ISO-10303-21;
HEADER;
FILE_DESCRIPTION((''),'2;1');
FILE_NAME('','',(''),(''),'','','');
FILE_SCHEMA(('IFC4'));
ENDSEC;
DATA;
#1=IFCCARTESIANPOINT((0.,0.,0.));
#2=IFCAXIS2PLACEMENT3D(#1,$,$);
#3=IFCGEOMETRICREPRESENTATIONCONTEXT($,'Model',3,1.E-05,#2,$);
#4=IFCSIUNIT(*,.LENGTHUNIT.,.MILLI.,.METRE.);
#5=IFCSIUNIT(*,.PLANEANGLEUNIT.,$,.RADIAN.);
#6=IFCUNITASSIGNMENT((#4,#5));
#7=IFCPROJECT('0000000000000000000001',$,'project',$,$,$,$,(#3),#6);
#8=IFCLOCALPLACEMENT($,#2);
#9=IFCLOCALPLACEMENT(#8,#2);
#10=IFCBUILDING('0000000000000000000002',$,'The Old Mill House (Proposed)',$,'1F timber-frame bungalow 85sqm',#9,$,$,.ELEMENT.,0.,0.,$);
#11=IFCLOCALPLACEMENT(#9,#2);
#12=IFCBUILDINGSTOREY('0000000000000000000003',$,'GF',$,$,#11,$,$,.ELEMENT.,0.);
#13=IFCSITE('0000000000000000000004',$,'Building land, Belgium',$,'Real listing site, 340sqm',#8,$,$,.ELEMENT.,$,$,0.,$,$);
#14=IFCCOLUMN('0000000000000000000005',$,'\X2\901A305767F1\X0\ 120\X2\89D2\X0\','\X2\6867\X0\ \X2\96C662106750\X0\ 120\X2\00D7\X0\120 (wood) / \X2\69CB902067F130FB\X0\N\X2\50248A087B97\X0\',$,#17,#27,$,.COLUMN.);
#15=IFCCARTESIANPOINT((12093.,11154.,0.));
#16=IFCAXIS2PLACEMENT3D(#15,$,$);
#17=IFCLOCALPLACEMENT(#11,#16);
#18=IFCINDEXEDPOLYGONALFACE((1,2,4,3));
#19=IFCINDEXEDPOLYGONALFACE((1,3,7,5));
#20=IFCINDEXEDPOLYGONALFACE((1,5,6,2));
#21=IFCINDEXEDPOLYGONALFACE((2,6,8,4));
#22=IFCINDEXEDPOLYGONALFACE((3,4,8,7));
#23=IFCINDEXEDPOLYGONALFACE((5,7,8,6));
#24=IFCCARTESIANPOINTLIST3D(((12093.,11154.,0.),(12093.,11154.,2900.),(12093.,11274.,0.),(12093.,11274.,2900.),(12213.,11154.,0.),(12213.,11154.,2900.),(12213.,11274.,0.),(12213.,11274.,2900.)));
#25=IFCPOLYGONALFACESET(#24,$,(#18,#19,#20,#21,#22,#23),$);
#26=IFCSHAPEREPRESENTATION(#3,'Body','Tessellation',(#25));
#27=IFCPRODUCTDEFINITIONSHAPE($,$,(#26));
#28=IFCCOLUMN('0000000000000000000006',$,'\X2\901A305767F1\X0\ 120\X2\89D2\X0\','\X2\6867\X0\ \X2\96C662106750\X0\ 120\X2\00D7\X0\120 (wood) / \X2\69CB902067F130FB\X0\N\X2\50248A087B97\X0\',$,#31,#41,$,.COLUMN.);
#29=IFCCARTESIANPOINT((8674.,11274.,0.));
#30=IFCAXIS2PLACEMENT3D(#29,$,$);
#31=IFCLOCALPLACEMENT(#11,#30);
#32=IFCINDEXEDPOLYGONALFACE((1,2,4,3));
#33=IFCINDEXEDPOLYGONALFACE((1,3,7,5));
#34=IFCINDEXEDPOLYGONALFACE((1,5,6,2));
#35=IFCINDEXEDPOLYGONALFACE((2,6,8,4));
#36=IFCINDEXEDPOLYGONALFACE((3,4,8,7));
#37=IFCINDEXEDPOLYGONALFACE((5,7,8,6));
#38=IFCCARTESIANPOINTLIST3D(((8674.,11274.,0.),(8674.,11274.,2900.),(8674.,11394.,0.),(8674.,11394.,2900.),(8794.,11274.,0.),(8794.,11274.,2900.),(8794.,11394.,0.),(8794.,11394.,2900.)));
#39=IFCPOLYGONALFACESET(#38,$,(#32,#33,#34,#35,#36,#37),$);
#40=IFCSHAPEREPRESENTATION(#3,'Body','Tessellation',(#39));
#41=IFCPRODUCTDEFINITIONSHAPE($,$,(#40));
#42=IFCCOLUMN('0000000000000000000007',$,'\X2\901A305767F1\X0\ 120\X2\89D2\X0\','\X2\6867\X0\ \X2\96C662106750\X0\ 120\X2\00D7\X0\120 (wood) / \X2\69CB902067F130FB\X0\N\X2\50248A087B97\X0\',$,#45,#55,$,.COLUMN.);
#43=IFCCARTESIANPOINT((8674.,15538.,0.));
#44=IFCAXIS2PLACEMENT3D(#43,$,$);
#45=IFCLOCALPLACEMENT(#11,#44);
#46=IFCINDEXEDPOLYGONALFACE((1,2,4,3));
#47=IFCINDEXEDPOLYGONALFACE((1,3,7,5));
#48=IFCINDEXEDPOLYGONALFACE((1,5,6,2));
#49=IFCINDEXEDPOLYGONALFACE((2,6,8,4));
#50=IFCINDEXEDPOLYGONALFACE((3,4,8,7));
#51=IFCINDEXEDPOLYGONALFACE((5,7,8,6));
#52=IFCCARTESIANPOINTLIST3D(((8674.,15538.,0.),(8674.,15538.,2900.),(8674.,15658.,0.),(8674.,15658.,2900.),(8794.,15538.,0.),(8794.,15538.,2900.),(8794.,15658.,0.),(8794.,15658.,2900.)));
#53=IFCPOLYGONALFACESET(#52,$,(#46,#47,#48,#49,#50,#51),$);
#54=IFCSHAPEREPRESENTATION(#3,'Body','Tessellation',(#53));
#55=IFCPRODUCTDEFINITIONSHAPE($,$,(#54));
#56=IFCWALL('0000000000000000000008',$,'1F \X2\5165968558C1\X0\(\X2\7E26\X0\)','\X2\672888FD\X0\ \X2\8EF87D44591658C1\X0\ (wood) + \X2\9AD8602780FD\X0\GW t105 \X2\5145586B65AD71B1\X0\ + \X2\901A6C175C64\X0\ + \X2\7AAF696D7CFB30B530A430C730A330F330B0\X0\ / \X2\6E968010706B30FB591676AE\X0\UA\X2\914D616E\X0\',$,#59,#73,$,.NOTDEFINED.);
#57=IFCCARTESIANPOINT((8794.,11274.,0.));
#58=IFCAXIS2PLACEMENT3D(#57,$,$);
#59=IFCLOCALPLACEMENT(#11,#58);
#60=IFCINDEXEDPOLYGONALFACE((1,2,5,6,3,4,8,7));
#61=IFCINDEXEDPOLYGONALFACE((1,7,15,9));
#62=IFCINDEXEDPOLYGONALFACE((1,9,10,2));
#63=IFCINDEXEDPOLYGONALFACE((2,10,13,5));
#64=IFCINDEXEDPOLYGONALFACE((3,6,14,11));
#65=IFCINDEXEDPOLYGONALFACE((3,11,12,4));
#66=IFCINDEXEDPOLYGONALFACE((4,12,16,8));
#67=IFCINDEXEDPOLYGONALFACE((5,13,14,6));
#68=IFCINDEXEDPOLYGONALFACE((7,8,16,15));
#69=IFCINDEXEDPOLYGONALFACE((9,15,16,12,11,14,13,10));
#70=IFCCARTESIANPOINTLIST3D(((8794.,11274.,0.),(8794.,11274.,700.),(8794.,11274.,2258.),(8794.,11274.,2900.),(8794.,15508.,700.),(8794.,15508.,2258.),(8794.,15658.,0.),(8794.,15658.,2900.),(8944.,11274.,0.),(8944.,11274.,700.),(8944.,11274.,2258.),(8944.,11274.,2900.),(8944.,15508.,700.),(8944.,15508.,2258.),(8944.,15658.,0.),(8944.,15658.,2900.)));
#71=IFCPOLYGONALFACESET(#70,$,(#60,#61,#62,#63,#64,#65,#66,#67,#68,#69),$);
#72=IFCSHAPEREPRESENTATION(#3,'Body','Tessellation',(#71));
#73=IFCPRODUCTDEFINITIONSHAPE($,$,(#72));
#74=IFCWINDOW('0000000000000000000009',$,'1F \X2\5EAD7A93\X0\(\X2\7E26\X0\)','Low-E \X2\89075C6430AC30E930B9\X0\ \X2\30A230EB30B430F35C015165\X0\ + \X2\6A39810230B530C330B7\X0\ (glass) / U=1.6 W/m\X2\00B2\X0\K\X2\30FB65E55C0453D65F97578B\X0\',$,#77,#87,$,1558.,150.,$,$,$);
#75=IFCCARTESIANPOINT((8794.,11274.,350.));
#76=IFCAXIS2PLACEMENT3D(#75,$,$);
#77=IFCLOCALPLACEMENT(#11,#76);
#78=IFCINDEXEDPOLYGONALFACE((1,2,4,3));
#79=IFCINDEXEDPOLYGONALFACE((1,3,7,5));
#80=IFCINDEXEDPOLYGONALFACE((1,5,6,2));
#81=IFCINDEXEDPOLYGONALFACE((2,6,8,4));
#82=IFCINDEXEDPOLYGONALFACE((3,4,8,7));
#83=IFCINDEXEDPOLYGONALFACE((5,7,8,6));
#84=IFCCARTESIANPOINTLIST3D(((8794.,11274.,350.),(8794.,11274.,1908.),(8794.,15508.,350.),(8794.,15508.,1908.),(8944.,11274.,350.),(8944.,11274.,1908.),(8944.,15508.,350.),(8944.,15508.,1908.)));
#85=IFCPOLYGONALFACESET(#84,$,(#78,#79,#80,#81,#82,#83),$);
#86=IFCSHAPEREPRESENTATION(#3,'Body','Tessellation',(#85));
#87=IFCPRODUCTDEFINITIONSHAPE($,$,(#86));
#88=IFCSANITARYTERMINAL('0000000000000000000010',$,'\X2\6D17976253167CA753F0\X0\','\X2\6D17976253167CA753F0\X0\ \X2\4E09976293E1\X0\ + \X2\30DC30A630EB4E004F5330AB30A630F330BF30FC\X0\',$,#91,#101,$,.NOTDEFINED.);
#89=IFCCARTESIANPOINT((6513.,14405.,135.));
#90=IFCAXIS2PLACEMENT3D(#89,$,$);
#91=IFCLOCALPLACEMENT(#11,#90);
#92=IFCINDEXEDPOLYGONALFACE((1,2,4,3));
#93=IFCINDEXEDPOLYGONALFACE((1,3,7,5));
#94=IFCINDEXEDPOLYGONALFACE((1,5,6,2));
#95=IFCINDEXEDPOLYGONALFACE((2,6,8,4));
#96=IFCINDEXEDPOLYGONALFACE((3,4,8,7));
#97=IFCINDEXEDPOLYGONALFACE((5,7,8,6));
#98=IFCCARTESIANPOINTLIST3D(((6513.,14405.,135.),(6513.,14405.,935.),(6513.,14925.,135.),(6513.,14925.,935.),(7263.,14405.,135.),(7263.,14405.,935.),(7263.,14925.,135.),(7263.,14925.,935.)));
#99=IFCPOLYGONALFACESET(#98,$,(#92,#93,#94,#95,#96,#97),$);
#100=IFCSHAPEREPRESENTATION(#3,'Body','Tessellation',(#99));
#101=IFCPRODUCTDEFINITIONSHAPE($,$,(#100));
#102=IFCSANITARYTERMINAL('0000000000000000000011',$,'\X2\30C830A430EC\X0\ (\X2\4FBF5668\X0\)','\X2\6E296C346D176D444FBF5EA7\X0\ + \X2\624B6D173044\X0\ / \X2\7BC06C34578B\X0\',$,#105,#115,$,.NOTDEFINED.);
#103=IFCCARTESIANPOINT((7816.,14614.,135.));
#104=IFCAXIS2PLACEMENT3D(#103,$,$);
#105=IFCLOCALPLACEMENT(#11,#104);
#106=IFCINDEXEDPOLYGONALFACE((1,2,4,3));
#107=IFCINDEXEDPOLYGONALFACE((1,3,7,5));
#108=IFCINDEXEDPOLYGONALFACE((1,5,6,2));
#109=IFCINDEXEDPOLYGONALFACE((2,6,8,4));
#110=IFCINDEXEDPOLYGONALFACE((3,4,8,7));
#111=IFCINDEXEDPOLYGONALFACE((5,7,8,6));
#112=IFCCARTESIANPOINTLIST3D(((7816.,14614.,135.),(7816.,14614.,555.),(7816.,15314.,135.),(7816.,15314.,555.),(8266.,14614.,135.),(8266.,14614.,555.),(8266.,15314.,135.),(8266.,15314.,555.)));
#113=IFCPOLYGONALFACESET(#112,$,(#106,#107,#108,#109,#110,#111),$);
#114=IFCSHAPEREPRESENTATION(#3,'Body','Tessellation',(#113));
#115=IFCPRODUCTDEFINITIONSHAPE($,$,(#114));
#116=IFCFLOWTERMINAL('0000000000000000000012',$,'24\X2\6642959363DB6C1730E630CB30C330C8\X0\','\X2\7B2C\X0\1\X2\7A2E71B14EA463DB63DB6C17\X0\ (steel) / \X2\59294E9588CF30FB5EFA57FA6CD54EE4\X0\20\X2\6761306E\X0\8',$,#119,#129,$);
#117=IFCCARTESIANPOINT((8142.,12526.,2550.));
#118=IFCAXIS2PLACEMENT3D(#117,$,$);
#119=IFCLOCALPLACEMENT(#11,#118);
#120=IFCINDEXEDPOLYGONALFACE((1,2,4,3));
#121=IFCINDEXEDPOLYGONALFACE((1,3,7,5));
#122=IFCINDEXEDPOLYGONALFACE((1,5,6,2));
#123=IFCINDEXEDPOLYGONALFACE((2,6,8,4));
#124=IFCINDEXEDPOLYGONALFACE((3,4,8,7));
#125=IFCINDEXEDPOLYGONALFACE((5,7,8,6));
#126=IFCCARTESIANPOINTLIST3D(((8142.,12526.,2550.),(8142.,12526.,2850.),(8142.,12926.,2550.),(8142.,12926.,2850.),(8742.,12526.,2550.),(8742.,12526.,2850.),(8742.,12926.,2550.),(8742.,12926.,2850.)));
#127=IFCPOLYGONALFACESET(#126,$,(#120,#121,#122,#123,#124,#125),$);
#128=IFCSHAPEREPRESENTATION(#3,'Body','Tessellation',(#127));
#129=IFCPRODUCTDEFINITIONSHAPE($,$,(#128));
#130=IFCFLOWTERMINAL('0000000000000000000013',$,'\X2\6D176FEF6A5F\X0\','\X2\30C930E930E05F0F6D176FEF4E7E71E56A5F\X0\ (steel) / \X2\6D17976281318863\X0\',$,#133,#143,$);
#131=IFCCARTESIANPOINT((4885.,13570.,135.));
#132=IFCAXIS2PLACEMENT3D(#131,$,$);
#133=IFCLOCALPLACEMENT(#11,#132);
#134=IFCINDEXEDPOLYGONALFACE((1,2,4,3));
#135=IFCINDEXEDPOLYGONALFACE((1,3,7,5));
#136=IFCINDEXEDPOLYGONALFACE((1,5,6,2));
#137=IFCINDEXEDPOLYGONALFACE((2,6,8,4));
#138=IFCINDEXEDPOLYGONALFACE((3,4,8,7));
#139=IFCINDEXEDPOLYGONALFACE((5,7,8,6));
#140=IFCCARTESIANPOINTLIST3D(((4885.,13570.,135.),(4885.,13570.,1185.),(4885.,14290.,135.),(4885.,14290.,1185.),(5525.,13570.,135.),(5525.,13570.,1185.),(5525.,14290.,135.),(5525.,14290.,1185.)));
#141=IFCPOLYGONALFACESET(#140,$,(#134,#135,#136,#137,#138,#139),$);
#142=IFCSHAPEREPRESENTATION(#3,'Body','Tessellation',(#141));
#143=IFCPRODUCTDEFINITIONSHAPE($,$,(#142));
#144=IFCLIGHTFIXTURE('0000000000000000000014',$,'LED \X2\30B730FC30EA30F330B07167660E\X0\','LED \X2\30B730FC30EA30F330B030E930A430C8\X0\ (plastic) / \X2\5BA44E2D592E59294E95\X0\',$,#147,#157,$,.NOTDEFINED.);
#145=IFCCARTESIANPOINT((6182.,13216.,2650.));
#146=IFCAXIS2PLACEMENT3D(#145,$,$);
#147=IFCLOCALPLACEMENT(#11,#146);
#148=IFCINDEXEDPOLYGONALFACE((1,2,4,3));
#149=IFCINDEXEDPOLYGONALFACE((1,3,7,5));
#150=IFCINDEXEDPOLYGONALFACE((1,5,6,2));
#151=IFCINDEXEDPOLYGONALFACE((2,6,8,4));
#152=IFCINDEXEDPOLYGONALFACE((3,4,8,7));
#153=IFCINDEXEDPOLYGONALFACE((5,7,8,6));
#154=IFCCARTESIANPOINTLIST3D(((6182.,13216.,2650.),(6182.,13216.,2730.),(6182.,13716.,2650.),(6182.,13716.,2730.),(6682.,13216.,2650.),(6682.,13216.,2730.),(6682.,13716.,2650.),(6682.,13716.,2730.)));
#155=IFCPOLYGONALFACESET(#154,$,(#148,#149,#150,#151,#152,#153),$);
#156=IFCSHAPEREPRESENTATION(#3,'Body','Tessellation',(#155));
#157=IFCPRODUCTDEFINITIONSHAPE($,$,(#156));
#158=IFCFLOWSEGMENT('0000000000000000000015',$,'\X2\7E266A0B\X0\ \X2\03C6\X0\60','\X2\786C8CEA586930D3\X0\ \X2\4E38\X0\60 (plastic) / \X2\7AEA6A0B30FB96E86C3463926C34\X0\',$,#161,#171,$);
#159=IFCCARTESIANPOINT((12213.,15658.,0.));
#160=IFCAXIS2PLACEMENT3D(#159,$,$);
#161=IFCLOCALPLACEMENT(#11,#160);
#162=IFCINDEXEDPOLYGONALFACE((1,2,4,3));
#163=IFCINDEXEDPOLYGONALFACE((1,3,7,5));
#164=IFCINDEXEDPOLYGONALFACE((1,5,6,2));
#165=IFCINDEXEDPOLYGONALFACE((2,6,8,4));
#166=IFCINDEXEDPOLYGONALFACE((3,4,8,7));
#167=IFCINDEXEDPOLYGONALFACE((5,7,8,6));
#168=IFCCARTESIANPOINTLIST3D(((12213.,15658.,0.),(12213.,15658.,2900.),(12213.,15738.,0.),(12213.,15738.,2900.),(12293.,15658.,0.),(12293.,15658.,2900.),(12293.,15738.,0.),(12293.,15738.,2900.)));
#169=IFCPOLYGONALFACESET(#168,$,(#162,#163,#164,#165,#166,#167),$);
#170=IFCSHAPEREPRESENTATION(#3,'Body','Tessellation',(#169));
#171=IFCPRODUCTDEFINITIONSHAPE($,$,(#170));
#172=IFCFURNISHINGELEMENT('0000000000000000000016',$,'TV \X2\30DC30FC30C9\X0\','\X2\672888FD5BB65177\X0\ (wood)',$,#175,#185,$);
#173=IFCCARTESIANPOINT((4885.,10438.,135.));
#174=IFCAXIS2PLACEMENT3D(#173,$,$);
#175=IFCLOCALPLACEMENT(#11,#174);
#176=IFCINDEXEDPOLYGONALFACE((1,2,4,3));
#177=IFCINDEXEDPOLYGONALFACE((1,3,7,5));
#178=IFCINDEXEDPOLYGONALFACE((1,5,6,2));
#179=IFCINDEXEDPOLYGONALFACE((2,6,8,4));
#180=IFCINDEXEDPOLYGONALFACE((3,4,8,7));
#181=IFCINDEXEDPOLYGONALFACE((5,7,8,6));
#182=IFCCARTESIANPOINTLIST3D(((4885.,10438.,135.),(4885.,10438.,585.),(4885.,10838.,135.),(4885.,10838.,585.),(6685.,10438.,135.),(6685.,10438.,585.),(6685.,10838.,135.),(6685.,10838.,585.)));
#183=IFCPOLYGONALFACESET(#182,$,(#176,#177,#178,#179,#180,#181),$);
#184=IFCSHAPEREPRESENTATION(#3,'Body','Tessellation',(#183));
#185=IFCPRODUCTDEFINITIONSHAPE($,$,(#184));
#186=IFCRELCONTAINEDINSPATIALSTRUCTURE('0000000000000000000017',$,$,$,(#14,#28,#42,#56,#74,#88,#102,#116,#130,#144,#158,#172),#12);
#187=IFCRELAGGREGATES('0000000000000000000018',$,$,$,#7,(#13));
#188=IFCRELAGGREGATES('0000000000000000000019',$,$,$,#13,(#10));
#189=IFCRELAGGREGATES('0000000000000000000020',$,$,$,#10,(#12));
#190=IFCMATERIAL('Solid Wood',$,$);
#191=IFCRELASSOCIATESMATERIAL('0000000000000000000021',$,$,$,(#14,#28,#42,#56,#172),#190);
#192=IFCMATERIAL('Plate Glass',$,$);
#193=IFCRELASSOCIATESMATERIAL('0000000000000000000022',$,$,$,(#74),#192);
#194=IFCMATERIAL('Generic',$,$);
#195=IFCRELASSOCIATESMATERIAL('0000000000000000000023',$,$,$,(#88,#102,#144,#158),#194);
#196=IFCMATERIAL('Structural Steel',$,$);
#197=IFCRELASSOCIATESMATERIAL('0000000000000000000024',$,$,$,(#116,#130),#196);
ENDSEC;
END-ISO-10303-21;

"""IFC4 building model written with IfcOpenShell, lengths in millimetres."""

from ifc_helpers import new_model, si_unit, frame, frame_2d, origin, place, context, project, spatial, rectangle, extrude, material, element, fill, save


model = new_model("IFC4")

# Units and contexts
model_context = context("Model", 3, precision=1e-05, world=origin())
ifc_project = project(units=[si_unit("LENGTHUNIT", "METRE", prefix="MILLI"), si_unit("PLANEANGLEUNIT", "RADIAN")], contexts=[model_context])

# Site, building, storey
site_placement = place(None, origin())
site = spatial("IfcSite", under=ifc_project, at=site_placement, Name="Building land, Belgium", ObjectType="Real listing site, 340sqm", CompositionType="ELEMENT", RefElevation=0.0)
building_placement = place(site_placement, origin())
building = spatial("IfcBuilding", under=site, at=building_placement, Name="The Old Mill House (Proposed)", ObjectType="1F timber-frame bungalow 85sqm", CompositionType="ELEMENT", ElevationOfRefHeight=0.0, ElevationOfTerrain=0.0)
storey_placement = place(building_placement, origin())
storey = spatial("IfcBuildingStorey", under=building, at=storey_placement, Name="GF", CompositionType="ELEMENT", Elevation=0.0)

# Columns
ifc_material_1 = material(Name="Solid Wood")
column_1_placement = place(storey_placement, frame((12093.0, 11154.0, 0.0)))
element("IfcColumn", 1, at=column_1_placement, inside=storey, material=ifc_material_1, Name="通し柱 120角", Description="桧 集成材 120×120 (wood) / 構造柱・N値計算", PredefinedType="COLUMN", context=model_context, shape_type="SweptSolid", body=[
    extrude(rectangle(XDim=120.0, YDim=120.0, at=frame_2d((60.0, 60.0))), frame((12093.0, 11154.0, 0.0)), (0.0, 0.0, 1.0), 2900.0),
])
column_2_placement = place(storey_placement, frame((8674.0, 11274.0, 0.0)))
element("IfcColumn", 2, at=column_2_placement, inside=storey, material=ifc_material_1, Name="通し柱 120角", Description="桧 集成材 120×120 (wood) / 構造柱・N値計算", PredefinedType="COLUMN", context=model_context, shape_type="SweptSolid", body=[
    extrude(rectangle(XDim=120.0, YDim=120.0, at=frame_2d((60.0, 60.0))), frame((8674.0, 11274.0, 0.0)), (0.0, 0.0, 1.0), 2900.0),
])
column_3_placement = place(storey_placement, frame((8674.0, 15538.0, 0.0)))
element("IfcColumn", 3, at=column_3_placement, inside=storey, material=ifc_material_1, Name="通し柱 120角", Description="桧 集成材 120×120 (wood) / 構造柱・N値計算", PredefinedType="COLUMN", context=model_context, shape_type="SweptSolid", body=[
    extrude(rectangle(XDim=120.0, YDim=120.0, at=frame_2d((60.0, 60.0))), frame((8674.0, 15538.0, 0.0)), (0.0, 0.0, 1.0), 2900.0),
])

# Wall, opening, window
wall_1_placement = place(storey_placement, frame((8794.0, 11274.0, 0.0)))
wall_1 = element("IfcWall", 4, at=wall_1_placement, inside=storey, material=ifc_material_1, Name="1F 入隅壁(縦)", Description="木製 軸組外壁 (wood) + 高性能GW t105 充填断熱 + 通気層 + 窯業系サイディング / 準耐火・外皮UA配慮", PredefinedType="NOTDEFINED", context=model_context, shape_type="SweptSolid", body=[
    extrude(rectangle(XDim=150.0, YDim=4384.0, at=frame_2d((75.0, 2192.0))), frame((8794.0, 11274.0, 0.0)), (0.0, 0.0, 1.0), 2900.0),
])
opening_placement = place(storey_placement, frame((8794.0, 11274.0, 350.0)))
opening = element("IfcOpeningElement", 5, at=opening_placement, cuts=wall_1, PredefinedType="NOTDEFINED", context=model_context, shape_type="SweptSolid", body=[
    extrude(rectangle(XDim=150.0, YDim=4234.0, at=frame_2d((75.0, 2117.0))), frame((8794.0, 11274.0, 350.0)), (0.0, 0.0, 1.0), 1558.0),
])
ifc_material_2 = material(Name="Plate Glass")
window_placement = place(storey_placement, frame((8794.0, 11274.0, 350.0)))
window = element("IfcWindow", 6, at=window_placement, inside=storey, material=ifc_material_2, Name="1F 庭窓(縦)", Description="Low-E 複層ガラス アルゴン封入 + 樹脂サッシ (glass) / U=1.6 W/m²K・日射取得型", OverallHeight=1558.0, OverallWidth=150.0, context=model_context, shape_type="SweptSolid", body=[
    extrude(rectangle(XDim=150.0, YDim=4234.0, at=frame_2d((75.0, 2117.0))), frame((8794.0, 11274.0, 350.0)), (0.0, 0.0, 1.0), 1558.0),
])
fill(opening, window)

# Sanitary terminals
ifc_material_3 = material(Name="Generic")
sanitary_terminal_1_placement = place(storey_placement, frame((6513.0, 14405.0, 135.0)))
element("IfcSanitaryTerminal", 7, at=sanitary_terminal_1_placement, inside=storey, material=ifc_material_3, Name="洗面化粧台", Description="洗面化粧台 三面鏡 + ボウル一体カウンター", PredefinedType="NOTDEFINED", context=model_context, shape_type="SweptSolid", body=[
    extrude(rectangle(XDim=750.0, YDim=520.0, at=frame_2d((375.0, 260.0))), frame((6513.0, 14405.0, 135.0)), (0.0, 0.0, 1.0), 800.0),
])
sanitary_terminal_2_placement = place(storey_placement, frame((7816.0, 14614.0, 135.0)))
element("IfcSanitaryTerminal", 8, at=sanitary_terminal_2_placement, inside=storey, material=ifc_material_3, Name="トイレ (便器)", Description="温水洗浄便座 + 手洗い / 節水型", PredefinedType="NOTDEFINED", context=model_context, shape_type="SweptSolid", body=[
    extrude(rectangle(XDim=450.0, YDim=700.0, at=frame_2d((225.0, 350.0))), frame((7816.0, 14614.0, 135.0)), (0.0, 0.0, 1.0), 420.0),
])

# Flow terminals
ifc_material_4 = material(Name="Structural Steel")
flow_terminal_1_placement = place(storey_placement, frame((8142.0, 12526.0, 2550.0)))
element("IfcFlowTerminal", 9, at=flow_terminal_1_placement, inside=storey, material=ifc_material_4, Name="24時間換気ユニット", Description="第1種熱交換換気 (steel) / 天井裏・建基法令20条の8", context=model_context, shape_type="SweptSolid", body=[
    extrude(rectangle(XDim=600.0, YDim=400.0, at=frame_2d((300.0, 200.0))), frame((8142.0, 12526.0, 2550.0)), (0.0, 0.0, 1.0), 300.0),
])
flow_terminal_2_placement = place(storey_placement, frame((4885.0, 13570.0, 135.0)))
element("IfcFlowTerminal", 10, at=flow_terminal_2_placement, inside=storey, material=ifc_material_4, Name="洗濯機", Description="ドラム式洗濯乾燥機 (steel) / 洗面脱衣", context=model_context, shape_type="SweptSolid", body=[
    extrude(rectangle(XDim=640.0, YDim=720.0, at=frame_2d((320.0, 360.0))), frame((4885.0, 13570.0, 135.0)), (0.0, 0.0, 1.0), 1050.0),
])

# Light fixture
light_fixture_placement = place(storey_placement, frame((6182.0, 13216.0, 2650.0)))
element("IfcLightFixture", 11, at=light_fixture_placement, inside=storey, material=ifc_material_3, Name="LED シーリング照明", Description="LED シーリングライト (plastic) / 室中央天井", PredefinedType="NOTDEFINED", context=model_context, shape_type="SweptSolid", body=[
    extrude(rectangle(XDim=500.0, YDim=500.0, at=frame_2d((250.0, 250.0))), frame((6182.0, 13216.0, 2650.0)), (0.0, 0.0, 1.0), 80.0),
])

# Flow segment
flow_segment_placement = place(storey_placement, frame((12213.0, 15658.0, 0.0)))
element("IfcFlowSegment", 12, at=flow_segment_placement, inside=storey, material=ifc_material_3, Name="縦樋 φ60", Description="硬質塩ビ 丸60 (plastic) / 竪樋・雨水排水", context=model_context, shape_type="SweptSolid", body=[
    extrude(rectangle(XDim=80.0, YDim=80.0, at=frame_2d((40.0, 40.0))), frame((12213.0, 15658.0, 0.0)), (0.0, 0.0, 1.0), 2900.0),
])

# Furnishing element
furnishing_placement = place(storey_placement, frame((4885.0, 10438.0, 135.0)))
element("IfcFurnishingElement", 13, at=furnishing_placement, inside=storey, material=ifc_material_1, Name="TV ボード", Description="木製家具 (wood)", context=model_context, shape_type="SweptSolid", body=[
    extrude(rectangle(XDim=1800.0, YDim=400.0, at=frame_2d((900.0, 200.0))), frame((4885.0, 10438.0, 135.0)), (0.0, 0.0, 1.0), 450.0),
])

save(model, "model.ifc")
